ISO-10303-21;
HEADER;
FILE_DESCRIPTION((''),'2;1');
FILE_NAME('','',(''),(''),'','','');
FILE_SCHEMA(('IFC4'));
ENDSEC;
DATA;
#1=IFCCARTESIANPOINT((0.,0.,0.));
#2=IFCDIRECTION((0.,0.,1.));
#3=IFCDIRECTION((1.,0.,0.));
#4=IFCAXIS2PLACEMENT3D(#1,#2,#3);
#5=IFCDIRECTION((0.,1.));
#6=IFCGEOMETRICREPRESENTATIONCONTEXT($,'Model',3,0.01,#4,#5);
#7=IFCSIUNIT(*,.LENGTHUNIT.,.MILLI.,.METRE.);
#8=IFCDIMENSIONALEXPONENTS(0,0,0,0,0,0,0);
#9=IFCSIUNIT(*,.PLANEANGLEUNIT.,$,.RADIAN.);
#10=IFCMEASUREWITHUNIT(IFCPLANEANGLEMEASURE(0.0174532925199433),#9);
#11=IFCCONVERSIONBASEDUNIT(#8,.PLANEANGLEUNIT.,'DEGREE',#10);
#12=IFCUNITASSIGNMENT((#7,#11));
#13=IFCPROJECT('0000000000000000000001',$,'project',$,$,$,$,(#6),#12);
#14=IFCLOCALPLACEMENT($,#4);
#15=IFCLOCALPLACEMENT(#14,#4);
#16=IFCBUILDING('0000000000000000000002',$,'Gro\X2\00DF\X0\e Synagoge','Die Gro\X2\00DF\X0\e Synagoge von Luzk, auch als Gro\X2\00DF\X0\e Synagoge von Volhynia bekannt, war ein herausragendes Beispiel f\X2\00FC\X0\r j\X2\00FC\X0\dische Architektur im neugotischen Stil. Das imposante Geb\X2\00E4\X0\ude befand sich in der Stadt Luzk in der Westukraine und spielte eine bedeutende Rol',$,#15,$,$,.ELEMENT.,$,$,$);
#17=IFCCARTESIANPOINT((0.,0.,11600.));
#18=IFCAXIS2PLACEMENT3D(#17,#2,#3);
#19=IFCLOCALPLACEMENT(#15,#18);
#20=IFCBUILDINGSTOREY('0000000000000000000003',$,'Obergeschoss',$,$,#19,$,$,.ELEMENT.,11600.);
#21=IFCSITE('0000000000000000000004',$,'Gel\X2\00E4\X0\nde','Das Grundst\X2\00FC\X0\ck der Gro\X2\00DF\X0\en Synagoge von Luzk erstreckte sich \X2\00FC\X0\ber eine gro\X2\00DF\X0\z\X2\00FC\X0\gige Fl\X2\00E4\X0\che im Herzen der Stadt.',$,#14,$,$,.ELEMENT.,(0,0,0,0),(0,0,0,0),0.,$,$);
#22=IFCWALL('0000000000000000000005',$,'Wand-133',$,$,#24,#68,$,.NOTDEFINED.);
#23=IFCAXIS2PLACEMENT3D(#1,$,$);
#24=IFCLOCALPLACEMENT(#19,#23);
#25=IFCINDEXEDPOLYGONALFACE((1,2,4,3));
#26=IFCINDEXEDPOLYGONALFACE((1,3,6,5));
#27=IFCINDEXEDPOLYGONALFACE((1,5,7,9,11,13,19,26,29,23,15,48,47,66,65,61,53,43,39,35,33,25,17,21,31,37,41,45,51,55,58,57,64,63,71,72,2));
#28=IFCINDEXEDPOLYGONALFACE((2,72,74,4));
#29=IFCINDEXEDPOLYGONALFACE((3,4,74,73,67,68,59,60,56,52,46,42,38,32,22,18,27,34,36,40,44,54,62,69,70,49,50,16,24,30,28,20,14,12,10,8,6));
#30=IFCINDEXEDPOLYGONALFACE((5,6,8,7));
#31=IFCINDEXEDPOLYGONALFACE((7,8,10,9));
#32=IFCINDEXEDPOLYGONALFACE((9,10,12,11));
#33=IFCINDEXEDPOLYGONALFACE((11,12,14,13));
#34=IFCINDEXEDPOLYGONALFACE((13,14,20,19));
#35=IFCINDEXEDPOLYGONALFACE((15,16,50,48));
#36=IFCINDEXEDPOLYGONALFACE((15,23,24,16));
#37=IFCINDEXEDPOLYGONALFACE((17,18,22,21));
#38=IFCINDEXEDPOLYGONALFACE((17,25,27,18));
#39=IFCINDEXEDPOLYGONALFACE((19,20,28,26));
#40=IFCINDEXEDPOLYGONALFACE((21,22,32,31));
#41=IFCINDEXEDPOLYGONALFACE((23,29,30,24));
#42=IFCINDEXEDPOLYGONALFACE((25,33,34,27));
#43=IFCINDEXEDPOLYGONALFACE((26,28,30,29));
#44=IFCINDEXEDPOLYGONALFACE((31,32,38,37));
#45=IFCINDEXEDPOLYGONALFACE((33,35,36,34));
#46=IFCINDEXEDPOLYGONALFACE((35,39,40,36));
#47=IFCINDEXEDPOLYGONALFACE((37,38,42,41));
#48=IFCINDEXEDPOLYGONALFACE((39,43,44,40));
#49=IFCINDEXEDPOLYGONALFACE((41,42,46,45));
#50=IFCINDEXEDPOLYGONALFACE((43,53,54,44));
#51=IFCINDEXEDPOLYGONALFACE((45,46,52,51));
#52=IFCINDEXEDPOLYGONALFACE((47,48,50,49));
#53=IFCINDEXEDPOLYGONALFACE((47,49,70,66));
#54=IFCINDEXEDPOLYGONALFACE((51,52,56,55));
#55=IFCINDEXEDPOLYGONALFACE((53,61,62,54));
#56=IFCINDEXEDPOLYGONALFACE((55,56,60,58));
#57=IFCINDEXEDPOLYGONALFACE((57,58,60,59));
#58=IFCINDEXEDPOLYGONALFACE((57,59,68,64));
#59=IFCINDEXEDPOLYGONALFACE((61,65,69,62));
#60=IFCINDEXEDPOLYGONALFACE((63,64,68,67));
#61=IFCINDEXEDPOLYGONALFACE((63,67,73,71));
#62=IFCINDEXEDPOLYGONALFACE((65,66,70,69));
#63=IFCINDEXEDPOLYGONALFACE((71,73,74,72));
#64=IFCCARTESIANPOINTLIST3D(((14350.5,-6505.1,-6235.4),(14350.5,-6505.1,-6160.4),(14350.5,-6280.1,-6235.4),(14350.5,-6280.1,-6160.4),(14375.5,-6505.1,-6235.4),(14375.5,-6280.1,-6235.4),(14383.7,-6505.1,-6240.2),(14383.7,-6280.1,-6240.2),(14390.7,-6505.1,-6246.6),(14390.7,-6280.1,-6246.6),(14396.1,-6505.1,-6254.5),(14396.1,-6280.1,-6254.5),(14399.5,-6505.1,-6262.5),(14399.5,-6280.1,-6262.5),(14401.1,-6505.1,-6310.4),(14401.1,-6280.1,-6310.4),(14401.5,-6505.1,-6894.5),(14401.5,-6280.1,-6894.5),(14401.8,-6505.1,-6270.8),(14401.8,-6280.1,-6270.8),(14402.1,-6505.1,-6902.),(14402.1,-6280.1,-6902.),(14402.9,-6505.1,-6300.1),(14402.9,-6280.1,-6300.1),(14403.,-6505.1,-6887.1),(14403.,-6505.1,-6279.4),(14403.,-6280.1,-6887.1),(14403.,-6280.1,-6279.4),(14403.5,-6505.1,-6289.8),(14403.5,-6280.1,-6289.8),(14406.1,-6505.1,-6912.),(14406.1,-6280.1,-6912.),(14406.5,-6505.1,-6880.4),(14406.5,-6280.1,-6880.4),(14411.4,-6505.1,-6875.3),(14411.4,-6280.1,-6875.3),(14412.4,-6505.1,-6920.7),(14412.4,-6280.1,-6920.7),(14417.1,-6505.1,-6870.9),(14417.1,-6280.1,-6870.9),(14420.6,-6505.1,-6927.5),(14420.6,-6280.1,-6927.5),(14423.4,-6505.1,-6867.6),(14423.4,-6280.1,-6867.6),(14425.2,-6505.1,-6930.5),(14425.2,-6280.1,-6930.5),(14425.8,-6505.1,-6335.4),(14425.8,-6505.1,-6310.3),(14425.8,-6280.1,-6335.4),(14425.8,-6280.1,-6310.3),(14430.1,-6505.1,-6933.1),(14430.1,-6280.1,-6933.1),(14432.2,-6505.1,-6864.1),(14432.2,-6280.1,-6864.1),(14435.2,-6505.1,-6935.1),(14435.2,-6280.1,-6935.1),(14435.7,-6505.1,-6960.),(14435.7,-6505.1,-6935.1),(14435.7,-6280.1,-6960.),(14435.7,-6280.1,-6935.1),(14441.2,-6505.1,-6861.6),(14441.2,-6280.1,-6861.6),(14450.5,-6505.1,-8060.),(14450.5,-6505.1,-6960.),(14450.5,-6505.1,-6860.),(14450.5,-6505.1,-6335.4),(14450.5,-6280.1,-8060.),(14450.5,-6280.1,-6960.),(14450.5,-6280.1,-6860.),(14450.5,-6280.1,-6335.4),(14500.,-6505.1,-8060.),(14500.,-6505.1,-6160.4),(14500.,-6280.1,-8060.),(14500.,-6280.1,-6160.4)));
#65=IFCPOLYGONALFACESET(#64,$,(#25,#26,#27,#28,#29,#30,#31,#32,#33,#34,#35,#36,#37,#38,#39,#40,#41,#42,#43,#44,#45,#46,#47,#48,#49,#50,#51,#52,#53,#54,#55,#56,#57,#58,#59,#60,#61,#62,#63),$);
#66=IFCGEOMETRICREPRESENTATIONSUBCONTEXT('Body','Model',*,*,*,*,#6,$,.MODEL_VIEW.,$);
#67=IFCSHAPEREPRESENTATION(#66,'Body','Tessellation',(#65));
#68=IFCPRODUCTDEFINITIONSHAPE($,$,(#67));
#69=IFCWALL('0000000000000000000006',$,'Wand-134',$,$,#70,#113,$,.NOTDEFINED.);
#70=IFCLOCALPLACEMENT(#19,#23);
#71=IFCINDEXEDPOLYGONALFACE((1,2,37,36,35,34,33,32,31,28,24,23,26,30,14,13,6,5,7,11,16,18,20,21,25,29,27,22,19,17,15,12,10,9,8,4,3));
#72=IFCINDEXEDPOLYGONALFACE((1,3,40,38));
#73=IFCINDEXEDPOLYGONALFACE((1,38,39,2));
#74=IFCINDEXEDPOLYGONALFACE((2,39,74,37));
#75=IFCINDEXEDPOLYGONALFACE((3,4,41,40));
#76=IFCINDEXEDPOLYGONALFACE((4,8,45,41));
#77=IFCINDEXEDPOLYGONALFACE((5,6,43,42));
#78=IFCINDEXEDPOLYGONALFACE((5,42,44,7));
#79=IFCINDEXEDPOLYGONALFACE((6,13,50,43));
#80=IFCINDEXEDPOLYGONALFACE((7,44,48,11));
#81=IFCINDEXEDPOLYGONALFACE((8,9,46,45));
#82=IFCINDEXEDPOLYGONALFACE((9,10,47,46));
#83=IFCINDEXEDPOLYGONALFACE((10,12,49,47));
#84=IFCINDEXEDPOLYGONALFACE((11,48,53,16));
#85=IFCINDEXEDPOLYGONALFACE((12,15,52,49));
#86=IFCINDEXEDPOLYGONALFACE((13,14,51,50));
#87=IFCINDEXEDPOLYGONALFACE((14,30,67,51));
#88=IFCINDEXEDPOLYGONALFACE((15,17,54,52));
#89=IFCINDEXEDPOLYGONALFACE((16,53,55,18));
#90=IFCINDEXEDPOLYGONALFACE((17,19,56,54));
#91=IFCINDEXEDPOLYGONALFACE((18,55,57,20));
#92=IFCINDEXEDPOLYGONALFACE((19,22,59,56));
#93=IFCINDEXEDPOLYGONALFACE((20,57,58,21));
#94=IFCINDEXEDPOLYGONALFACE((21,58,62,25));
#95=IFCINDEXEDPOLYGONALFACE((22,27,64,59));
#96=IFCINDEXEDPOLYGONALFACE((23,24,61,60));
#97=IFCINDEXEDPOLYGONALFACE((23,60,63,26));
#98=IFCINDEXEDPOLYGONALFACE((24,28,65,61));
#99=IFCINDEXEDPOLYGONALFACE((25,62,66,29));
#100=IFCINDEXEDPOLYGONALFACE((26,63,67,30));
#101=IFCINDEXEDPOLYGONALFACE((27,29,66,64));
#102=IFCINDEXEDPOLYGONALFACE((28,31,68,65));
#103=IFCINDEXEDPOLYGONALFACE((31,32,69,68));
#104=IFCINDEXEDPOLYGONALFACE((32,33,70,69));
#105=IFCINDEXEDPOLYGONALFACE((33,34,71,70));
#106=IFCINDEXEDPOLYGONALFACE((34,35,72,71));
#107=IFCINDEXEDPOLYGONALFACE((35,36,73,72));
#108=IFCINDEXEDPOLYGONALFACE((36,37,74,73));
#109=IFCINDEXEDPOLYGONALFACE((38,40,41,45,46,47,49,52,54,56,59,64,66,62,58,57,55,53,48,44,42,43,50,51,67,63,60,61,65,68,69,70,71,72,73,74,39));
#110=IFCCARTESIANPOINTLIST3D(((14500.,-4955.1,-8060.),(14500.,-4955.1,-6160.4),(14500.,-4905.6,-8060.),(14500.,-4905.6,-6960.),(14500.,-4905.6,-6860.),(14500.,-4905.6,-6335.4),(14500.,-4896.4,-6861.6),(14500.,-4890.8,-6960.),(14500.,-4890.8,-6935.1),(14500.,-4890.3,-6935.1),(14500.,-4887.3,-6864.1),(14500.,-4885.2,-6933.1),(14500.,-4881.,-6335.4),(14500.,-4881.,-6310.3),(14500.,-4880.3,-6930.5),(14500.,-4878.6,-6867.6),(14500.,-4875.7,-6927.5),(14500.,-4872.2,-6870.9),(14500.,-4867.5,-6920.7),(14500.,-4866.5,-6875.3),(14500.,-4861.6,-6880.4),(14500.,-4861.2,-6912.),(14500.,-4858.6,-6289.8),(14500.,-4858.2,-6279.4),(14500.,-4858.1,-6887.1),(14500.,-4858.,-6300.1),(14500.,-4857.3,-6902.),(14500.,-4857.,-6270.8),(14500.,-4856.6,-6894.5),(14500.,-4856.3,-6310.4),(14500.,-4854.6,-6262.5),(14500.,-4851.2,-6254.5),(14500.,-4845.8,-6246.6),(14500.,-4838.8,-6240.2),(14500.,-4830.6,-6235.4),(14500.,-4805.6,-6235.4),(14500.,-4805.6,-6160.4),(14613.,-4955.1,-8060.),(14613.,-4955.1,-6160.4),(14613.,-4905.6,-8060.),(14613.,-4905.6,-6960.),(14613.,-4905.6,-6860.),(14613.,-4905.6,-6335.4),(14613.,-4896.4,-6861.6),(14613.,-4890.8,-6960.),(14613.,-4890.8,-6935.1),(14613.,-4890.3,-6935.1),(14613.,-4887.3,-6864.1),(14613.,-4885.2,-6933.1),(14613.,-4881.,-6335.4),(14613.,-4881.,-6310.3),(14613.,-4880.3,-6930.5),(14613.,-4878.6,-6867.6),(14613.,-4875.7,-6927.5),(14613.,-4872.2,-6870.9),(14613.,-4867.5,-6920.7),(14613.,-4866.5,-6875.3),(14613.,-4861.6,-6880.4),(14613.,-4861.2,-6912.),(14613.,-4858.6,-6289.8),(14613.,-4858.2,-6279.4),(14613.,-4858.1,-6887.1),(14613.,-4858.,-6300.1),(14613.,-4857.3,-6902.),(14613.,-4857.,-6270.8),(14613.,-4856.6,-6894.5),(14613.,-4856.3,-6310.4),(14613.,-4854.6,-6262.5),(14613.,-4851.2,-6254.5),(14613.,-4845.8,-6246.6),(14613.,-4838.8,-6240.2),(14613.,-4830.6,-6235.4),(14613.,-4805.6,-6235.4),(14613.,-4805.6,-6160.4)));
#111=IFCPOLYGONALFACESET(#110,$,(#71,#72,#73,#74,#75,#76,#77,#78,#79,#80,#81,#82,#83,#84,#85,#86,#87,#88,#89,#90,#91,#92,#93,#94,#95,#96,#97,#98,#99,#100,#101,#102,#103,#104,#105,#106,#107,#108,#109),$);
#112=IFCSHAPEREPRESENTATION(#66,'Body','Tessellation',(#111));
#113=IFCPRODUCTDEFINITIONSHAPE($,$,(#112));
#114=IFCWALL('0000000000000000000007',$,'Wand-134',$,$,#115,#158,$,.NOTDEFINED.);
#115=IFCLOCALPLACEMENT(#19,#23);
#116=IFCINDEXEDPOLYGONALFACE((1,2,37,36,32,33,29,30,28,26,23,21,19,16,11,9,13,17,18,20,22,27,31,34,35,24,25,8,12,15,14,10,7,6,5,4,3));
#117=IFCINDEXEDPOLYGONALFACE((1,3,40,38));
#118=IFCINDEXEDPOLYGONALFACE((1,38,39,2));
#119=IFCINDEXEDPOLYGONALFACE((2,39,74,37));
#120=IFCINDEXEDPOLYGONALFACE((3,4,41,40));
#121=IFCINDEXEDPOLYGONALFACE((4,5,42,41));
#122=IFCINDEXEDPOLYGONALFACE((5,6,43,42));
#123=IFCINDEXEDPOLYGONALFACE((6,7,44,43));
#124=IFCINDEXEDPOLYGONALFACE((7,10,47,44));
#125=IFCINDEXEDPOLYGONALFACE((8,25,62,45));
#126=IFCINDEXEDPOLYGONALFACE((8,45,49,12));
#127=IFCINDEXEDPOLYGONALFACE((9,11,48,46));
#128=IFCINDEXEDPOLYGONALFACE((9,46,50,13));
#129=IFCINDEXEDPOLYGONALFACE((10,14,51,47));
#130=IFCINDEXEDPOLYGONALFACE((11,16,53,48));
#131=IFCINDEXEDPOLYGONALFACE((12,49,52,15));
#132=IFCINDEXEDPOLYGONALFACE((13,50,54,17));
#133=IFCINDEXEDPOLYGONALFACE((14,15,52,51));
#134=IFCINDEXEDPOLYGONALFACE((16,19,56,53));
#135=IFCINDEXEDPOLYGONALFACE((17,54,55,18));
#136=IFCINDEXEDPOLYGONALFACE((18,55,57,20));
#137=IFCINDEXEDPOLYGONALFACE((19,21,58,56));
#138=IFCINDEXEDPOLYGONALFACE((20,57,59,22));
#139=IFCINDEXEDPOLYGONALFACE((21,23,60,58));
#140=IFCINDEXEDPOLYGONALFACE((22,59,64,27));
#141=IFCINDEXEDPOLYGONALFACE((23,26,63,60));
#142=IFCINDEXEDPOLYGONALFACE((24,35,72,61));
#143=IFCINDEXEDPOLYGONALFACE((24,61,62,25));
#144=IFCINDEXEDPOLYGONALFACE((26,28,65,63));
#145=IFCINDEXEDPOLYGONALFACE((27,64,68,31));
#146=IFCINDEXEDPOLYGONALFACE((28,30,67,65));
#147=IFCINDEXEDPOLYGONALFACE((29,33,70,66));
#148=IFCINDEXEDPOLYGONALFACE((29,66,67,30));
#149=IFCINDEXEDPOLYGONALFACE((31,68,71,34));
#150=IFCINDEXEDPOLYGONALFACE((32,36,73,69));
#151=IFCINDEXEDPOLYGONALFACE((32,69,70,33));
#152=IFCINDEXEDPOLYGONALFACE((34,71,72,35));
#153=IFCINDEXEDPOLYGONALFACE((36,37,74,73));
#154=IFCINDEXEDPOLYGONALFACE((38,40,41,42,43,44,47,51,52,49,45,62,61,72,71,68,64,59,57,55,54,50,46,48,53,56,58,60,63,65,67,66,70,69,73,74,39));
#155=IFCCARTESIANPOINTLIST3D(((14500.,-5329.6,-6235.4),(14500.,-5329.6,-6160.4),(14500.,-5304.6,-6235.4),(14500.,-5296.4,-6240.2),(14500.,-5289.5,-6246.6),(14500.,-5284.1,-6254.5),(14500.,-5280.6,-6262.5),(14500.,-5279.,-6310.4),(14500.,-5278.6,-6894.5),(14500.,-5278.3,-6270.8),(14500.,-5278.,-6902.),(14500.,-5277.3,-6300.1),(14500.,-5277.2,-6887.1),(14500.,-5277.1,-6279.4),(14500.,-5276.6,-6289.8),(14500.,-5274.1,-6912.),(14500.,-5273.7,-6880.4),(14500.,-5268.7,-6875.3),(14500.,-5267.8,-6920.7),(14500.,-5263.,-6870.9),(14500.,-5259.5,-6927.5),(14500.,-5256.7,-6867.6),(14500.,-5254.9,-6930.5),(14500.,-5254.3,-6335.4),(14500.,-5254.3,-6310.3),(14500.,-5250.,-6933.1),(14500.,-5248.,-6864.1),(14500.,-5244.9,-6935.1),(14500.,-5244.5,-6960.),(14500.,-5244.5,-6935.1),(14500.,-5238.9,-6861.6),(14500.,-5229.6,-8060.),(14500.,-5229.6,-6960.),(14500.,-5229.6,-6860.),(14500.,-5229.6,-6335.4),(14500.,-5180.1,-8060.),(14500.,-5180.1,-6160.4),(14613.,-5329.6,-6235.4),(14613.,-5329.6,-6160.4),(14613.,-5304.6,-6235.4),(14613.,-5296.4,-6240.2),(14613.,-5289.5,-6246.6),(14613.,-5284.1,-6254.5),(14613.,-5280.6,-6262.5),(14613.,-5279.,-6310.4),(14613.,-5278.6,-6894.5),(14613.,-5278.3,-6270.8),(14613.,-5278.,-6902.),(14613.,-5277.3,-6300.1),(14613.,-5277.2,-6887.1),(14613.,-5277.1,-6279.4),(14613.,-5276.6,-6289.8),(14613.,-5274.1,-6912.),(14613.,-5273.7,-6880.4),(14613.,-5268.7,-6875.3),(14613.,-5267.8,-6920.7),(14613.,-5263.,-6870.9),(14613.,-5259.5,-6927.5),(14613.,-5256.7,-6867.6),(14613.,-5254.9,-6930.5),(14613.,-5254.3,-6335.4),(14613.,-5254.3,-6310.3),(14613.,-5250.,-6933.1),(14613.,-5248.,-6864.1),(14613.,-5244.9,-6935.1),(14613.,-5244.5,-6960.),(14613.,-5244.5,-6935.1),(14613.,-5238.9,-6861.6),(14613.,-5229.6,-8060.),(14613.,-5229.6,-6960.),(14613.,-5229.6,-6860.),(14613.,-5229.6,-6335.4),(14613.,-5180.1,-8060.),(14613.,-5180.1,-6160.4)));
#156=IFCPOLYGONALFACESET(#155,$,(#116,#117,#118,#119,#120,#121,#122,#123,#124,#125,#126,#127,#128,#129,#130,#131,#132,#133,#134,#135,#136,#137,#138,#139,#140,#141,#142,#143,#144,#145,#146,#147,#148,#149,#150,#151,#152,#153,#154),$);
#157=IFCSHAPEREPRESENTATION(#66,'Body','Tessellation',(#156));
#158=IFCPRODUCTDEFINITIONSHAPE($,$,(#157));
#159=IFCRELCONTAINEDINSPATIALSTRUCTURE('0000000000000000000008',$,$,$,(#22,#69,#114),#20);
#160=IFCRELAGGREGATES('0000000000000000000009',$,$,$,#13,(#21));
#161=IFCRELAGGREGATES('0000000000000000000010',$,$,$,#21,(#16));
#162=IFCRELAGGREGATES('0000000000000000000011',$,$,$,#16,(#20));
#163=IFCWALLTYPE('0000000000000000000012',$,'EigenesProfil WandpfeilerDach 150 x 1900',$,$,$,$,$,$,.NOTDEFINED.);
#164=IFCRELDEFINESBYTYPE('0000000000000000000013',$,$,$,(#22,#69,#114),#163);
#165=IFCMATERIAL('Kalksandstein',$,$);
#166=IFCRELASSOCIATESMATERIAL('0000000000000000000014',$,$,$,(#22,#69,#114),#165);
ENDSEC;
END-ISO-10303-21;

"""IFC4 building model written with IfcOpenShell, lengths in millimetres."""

from ifc_helpers import new_model, entity, si_unit, converted_unit, direction, frame, origin_with_axes, place, context, subcontext, project, spatial, line, arc, indexed_curve, outline, extrude, material, material_profile, profile_set, type_object, element, save


model = new_model("IFC4")

# Units and contexts
model_context = context("Model", 3, precision=0.01, world=origin_with_axes(), true_north=direction((0.0, 1.0)))
body_context = subcontext(model_context, "Body", "Model", "MODEL_VIEW")
ifc_project = project(units=[si_unit("LENGTHUNIT", "METRE", prefix="MILLI"), converted_unit("PLANEANGLEUNIT", "DEGREE", entity("IfcPlaneAngleMeasure", 0.0174532925199433), si_unit("PLANEANGLEUNIT", "RADIAN"), dimensions=[0, 0, 0, 0, 0, 0, 0])], contexts=[model_context])

# Site, building, storey
site_placement = place(None, origin_with_axes())
site = spatial("IfcSite", under=ifc_project, at=site_placement, Name="Gelände", Description="Das Grundstück der Großen Synagoge von Luzk erstreckte sich über eine großzügige Fläche im Herzen der Stadt.", CompositionType="ELEMENT", RefLatitude=(0, 0, 0, 0), RefLongitude=(0, 0, 0, 0), RefElevation=0.0)
building_placement = place(site_placement, origin_with_axes())
building = spatial("IfcBuilding", under=site, at=building_placement, Name="Große Synagoge", Description="Die Große Synagoge von Luzk, auch als Große Synagoge von Volhynia bekannt, war ein herausragendes Beispiel für jüdische Architektur im neugotischen Stil. Das imposante Gebäude befand sich in der Stadt Luzk in der Westukraine und spielte eine bedeutende Rol", CompositionType="ELEMENT")
storey_placement = place(building_placement, frame((0.0, 0.0, 11600.0), z_axis=(0.0, 0.0, 1.0), x_axis=(1.0, 0.0, 0.0)))
storey = spatial("IfcBuildingStorey", under=building, at=storey_placement, Name="Obergeschoss", CompositionType="ELEMENT", Elevation=11600.0)

# Walls
ifc_material_1 = material(Name="Kalksandstein")
ifc_material_profile = material_profile(ifc_material_1, outline(indexed_curve([(74.2, 1749.6), (98.9, 1749.6), (96.7, 1765.0), (97.0, 1780.5), (99.2, 1793.4), (103.9, 1805.5), (112.6, 1816.7), (124.5, 1824.6), (149.5, 1824.6), (149.5, 1899.6), (0.0, 1899.6), (0.0, 0.0), (49.5, 0.0), (49.5, 1100.0), (64.3, 1100.0), (64.3, 1124.9), (64.8, 1124.9), (72.4, 1128.1), (79.4, 1132.4), (91.1, 1143.4), (97.9, 1157.9), (98.0, 1169.2), (93.5, 1179.5), (85.8, 1187.0), (76.6, 1192.3), (63.3, 1197.2), (49.5, 1200.0), (49.5, 1724.6), (74.2, 1724.6)], segments=[line(1, 2), arc(2, 3, 4), arc(4, 5, 6), arc(6, 7, 8), line(8, 9, 10, 11, 12, 13, 14, 15, 16, 17), arc(17, 18, 19), arc(19, 20, 21), arc(21, 22, 23), arc(23, 24, 25), arc(25, 26, 27), line(27, 28, 29, 1)])), Name="Kalksandstein")
ifc_profile_set = profile_set([ifc_material_profile], Name="EigenesProfil WandpfeilerDach")
wall_type_1 = type_object("IfcWallType", Name="EigenesProfil WandpfeilerDach 150 x 1900", PredefinedType="NOTDEFINED")
wall_1_placement = place(storey_placement, frame((14500.0, -6280.1, -8060.0), z_axis=(0.0, 0.0, 1.0), x_axis=(0.0, -1.0, 0.0)))
element("IfcWall", 1, at=wall_1_placement, inside=storey, type_object=wall_type_1, material=ifc_profile_set, Name="Wand-133", PredefinedType="NOTDEFINED", context=body_context, shape_type="SweptSolid", body=[
    extrude(outline(indexed_curve([(74.2, 1749.6), (98.9, 1749.6), (96.7, 1765.0), (97.0, 1780.5), (99.2, 1793.4), (103.9, 1805.5), (112.6, 1816.7), (124.5, 1824.6), (149.5, 1824.6), (149.5, 1899.6), (0.0, 1899.6), (0.0, 0.0), (49.5, 0.0), (49.5, 1100.0), (64.3, 1100.0), (64.3, 1124.9), (64.8, 1124.9), (72.4, 1128.1), (79.4, 1132.4), (91.1, 1143.4), (97.9, 1157.9), (98.0, 1169.2), (93.5, 1179.5), (85.8, 1187.0), (76.6, 1192.3), (63.3, 1197.2), (49.5, 1200.0), (49.5, 1724.6), (74.2, 1724.6)], segments=[line(1, 2), arc(2, 3, 4), arc(4, 5, 6), arc(6, 7, 8), line(8, 9, 10, 11, 12, 13, 14, 15, 16, 17), arc(17, 18, 19), arc(19, 20, 21), arc(21, 22, 23), arc(23, 24, 25), arc(25, 26, 27), line(27, 28, 29, 1)])), frame((0.0, 0.0, 0.0), z_axis=(-1.0, 0.0, 0.0), x_axis=(0.0, -1.0, 0.0)), (0.0, 0.0, -1.0), 225.0),
])
wall_2_placement = place(storey_placement, frame((14500.0, -4955.1, -8060.0), z_axis=(0.0, 0.0, 1.0), x_axis=(1.0, 0.0, 0.0)))
element("IfcWall", 2, at=wall_2_placement, inside=storey, type_object=wall_type_1, material=ifc_profile_set, Name="Wand-134", PredefinedType="NOTDEFINED", context=body_context, shape_type="SweptSolid", body=[
    extrude(outline(indexed_curve([(74.2, 1749.6), (98.9, 1749.6), (96.7, 1765.0), (97.0, 1780.5), (99.2, 1793.4), (103.9, 1805.5), (112.6, 1816.7), (124.5, 1824.6), (149.5, 1824.6), (149.5, 1899.6), (0.0, 1899.6), (0.0, 0.0), (49.5, 0.0), (49.5, 1100.0), (64.3, 1100.0), (64.3, 1124.9), (64.8, 1124.9), (72.4, 1128.1), (79.4, 1132.4), (91.1, 1143.4), (97.9, 1157.9), (98.0, 1169.2), (93.5, 1179.5), (85.8, 1187.0), (76.6, 1192.3), (63.3, 1197.2), (49.5, 1200.0), (49.5, 1724.6), (74.2, 1724.6)], segments=[line(1, 2), arc(2, 3, 4), arc(4, 5, 6), arc(6, 7, 8), line(8, 9, 10, 11, 12, 13, 14, 15, 16, 17), arc(17, 18, 19), arc(19, 20, 21), arc(21, 22, 23), arc(23, 24, 25), arc(25, 26, 27), line(27, 28, 29, 1)])), frame((0.0, 0.0, 0.0), z_axis=(1.0, 0.0, 0.0), x_axis=(0.0, 1.0, 0.0)), (0.0, 0.0, 1.0), 113.0),
])
wall_3_placement = place(storey_placement, frame((14500.0, -5180.1, -8060.0), z_axis=(0.0, 0.0, 1.0), x_axis=(1.0, 0.0, 0.0)))
element("IfcWall", 3, at=wall_3_placement, inside=storey, type_object=wall_type_1, material=ifc_profile_set, Name="Wand-134", PredefinedType="NOTDEFINED", context=body_context, shape_type="SweptSolid", body=[
    extrude(outline(indexed_curve([(74.2, 1749.6), (98.9, 1749.6), (96.7, 1765.0), (97.0, 1780.5), (99.2, 1793.4), (103.9, 1805.5), (112.6, 1816.7), (124.5, 1824.6), (149.5, 1824.6), (149.5, 1899.6), (0.0, 1899.6), (0.0, 0.0), (49.5, 0.0), (49.5, 1100.0), (64.3, 1100.0), (64.3, 1124.9), (64.8, 1124.9), (72.4, 1128.1), (79.4, 1132.4), (91.1, 1143.4), (97.9, 1157.9), (98.0, 1169.2), (93.5, 1179.5), (85.8, 1187.0), (76.6, 1192.3), (63.3, 1197.2), (49.5, 1200.0), (49.5, 1724.6), (74.2, 1724.6)], segments=[line(1, 2), arc(2, 3, 4), arc(4, 5, 6), arc(6, 7, 8), line(8, 9, 10, 11, 12, 13, 14, 15, 16, 17), arc(17, 18, 19), arc(19, 20, 21), arc(21, 22, 23), arc(23, 24, 25), arc(25, 26, 27), line(27, 28, 29, 1)])), frame((0.0, 0.0, 0.0), z_axis=(-1.0, 0.0, 0.0), x_axis=(0.0, -1.0, 0.0)), (0.0, 0.0, -1.0), 113.0),
])

save(model, "model.ifc")
